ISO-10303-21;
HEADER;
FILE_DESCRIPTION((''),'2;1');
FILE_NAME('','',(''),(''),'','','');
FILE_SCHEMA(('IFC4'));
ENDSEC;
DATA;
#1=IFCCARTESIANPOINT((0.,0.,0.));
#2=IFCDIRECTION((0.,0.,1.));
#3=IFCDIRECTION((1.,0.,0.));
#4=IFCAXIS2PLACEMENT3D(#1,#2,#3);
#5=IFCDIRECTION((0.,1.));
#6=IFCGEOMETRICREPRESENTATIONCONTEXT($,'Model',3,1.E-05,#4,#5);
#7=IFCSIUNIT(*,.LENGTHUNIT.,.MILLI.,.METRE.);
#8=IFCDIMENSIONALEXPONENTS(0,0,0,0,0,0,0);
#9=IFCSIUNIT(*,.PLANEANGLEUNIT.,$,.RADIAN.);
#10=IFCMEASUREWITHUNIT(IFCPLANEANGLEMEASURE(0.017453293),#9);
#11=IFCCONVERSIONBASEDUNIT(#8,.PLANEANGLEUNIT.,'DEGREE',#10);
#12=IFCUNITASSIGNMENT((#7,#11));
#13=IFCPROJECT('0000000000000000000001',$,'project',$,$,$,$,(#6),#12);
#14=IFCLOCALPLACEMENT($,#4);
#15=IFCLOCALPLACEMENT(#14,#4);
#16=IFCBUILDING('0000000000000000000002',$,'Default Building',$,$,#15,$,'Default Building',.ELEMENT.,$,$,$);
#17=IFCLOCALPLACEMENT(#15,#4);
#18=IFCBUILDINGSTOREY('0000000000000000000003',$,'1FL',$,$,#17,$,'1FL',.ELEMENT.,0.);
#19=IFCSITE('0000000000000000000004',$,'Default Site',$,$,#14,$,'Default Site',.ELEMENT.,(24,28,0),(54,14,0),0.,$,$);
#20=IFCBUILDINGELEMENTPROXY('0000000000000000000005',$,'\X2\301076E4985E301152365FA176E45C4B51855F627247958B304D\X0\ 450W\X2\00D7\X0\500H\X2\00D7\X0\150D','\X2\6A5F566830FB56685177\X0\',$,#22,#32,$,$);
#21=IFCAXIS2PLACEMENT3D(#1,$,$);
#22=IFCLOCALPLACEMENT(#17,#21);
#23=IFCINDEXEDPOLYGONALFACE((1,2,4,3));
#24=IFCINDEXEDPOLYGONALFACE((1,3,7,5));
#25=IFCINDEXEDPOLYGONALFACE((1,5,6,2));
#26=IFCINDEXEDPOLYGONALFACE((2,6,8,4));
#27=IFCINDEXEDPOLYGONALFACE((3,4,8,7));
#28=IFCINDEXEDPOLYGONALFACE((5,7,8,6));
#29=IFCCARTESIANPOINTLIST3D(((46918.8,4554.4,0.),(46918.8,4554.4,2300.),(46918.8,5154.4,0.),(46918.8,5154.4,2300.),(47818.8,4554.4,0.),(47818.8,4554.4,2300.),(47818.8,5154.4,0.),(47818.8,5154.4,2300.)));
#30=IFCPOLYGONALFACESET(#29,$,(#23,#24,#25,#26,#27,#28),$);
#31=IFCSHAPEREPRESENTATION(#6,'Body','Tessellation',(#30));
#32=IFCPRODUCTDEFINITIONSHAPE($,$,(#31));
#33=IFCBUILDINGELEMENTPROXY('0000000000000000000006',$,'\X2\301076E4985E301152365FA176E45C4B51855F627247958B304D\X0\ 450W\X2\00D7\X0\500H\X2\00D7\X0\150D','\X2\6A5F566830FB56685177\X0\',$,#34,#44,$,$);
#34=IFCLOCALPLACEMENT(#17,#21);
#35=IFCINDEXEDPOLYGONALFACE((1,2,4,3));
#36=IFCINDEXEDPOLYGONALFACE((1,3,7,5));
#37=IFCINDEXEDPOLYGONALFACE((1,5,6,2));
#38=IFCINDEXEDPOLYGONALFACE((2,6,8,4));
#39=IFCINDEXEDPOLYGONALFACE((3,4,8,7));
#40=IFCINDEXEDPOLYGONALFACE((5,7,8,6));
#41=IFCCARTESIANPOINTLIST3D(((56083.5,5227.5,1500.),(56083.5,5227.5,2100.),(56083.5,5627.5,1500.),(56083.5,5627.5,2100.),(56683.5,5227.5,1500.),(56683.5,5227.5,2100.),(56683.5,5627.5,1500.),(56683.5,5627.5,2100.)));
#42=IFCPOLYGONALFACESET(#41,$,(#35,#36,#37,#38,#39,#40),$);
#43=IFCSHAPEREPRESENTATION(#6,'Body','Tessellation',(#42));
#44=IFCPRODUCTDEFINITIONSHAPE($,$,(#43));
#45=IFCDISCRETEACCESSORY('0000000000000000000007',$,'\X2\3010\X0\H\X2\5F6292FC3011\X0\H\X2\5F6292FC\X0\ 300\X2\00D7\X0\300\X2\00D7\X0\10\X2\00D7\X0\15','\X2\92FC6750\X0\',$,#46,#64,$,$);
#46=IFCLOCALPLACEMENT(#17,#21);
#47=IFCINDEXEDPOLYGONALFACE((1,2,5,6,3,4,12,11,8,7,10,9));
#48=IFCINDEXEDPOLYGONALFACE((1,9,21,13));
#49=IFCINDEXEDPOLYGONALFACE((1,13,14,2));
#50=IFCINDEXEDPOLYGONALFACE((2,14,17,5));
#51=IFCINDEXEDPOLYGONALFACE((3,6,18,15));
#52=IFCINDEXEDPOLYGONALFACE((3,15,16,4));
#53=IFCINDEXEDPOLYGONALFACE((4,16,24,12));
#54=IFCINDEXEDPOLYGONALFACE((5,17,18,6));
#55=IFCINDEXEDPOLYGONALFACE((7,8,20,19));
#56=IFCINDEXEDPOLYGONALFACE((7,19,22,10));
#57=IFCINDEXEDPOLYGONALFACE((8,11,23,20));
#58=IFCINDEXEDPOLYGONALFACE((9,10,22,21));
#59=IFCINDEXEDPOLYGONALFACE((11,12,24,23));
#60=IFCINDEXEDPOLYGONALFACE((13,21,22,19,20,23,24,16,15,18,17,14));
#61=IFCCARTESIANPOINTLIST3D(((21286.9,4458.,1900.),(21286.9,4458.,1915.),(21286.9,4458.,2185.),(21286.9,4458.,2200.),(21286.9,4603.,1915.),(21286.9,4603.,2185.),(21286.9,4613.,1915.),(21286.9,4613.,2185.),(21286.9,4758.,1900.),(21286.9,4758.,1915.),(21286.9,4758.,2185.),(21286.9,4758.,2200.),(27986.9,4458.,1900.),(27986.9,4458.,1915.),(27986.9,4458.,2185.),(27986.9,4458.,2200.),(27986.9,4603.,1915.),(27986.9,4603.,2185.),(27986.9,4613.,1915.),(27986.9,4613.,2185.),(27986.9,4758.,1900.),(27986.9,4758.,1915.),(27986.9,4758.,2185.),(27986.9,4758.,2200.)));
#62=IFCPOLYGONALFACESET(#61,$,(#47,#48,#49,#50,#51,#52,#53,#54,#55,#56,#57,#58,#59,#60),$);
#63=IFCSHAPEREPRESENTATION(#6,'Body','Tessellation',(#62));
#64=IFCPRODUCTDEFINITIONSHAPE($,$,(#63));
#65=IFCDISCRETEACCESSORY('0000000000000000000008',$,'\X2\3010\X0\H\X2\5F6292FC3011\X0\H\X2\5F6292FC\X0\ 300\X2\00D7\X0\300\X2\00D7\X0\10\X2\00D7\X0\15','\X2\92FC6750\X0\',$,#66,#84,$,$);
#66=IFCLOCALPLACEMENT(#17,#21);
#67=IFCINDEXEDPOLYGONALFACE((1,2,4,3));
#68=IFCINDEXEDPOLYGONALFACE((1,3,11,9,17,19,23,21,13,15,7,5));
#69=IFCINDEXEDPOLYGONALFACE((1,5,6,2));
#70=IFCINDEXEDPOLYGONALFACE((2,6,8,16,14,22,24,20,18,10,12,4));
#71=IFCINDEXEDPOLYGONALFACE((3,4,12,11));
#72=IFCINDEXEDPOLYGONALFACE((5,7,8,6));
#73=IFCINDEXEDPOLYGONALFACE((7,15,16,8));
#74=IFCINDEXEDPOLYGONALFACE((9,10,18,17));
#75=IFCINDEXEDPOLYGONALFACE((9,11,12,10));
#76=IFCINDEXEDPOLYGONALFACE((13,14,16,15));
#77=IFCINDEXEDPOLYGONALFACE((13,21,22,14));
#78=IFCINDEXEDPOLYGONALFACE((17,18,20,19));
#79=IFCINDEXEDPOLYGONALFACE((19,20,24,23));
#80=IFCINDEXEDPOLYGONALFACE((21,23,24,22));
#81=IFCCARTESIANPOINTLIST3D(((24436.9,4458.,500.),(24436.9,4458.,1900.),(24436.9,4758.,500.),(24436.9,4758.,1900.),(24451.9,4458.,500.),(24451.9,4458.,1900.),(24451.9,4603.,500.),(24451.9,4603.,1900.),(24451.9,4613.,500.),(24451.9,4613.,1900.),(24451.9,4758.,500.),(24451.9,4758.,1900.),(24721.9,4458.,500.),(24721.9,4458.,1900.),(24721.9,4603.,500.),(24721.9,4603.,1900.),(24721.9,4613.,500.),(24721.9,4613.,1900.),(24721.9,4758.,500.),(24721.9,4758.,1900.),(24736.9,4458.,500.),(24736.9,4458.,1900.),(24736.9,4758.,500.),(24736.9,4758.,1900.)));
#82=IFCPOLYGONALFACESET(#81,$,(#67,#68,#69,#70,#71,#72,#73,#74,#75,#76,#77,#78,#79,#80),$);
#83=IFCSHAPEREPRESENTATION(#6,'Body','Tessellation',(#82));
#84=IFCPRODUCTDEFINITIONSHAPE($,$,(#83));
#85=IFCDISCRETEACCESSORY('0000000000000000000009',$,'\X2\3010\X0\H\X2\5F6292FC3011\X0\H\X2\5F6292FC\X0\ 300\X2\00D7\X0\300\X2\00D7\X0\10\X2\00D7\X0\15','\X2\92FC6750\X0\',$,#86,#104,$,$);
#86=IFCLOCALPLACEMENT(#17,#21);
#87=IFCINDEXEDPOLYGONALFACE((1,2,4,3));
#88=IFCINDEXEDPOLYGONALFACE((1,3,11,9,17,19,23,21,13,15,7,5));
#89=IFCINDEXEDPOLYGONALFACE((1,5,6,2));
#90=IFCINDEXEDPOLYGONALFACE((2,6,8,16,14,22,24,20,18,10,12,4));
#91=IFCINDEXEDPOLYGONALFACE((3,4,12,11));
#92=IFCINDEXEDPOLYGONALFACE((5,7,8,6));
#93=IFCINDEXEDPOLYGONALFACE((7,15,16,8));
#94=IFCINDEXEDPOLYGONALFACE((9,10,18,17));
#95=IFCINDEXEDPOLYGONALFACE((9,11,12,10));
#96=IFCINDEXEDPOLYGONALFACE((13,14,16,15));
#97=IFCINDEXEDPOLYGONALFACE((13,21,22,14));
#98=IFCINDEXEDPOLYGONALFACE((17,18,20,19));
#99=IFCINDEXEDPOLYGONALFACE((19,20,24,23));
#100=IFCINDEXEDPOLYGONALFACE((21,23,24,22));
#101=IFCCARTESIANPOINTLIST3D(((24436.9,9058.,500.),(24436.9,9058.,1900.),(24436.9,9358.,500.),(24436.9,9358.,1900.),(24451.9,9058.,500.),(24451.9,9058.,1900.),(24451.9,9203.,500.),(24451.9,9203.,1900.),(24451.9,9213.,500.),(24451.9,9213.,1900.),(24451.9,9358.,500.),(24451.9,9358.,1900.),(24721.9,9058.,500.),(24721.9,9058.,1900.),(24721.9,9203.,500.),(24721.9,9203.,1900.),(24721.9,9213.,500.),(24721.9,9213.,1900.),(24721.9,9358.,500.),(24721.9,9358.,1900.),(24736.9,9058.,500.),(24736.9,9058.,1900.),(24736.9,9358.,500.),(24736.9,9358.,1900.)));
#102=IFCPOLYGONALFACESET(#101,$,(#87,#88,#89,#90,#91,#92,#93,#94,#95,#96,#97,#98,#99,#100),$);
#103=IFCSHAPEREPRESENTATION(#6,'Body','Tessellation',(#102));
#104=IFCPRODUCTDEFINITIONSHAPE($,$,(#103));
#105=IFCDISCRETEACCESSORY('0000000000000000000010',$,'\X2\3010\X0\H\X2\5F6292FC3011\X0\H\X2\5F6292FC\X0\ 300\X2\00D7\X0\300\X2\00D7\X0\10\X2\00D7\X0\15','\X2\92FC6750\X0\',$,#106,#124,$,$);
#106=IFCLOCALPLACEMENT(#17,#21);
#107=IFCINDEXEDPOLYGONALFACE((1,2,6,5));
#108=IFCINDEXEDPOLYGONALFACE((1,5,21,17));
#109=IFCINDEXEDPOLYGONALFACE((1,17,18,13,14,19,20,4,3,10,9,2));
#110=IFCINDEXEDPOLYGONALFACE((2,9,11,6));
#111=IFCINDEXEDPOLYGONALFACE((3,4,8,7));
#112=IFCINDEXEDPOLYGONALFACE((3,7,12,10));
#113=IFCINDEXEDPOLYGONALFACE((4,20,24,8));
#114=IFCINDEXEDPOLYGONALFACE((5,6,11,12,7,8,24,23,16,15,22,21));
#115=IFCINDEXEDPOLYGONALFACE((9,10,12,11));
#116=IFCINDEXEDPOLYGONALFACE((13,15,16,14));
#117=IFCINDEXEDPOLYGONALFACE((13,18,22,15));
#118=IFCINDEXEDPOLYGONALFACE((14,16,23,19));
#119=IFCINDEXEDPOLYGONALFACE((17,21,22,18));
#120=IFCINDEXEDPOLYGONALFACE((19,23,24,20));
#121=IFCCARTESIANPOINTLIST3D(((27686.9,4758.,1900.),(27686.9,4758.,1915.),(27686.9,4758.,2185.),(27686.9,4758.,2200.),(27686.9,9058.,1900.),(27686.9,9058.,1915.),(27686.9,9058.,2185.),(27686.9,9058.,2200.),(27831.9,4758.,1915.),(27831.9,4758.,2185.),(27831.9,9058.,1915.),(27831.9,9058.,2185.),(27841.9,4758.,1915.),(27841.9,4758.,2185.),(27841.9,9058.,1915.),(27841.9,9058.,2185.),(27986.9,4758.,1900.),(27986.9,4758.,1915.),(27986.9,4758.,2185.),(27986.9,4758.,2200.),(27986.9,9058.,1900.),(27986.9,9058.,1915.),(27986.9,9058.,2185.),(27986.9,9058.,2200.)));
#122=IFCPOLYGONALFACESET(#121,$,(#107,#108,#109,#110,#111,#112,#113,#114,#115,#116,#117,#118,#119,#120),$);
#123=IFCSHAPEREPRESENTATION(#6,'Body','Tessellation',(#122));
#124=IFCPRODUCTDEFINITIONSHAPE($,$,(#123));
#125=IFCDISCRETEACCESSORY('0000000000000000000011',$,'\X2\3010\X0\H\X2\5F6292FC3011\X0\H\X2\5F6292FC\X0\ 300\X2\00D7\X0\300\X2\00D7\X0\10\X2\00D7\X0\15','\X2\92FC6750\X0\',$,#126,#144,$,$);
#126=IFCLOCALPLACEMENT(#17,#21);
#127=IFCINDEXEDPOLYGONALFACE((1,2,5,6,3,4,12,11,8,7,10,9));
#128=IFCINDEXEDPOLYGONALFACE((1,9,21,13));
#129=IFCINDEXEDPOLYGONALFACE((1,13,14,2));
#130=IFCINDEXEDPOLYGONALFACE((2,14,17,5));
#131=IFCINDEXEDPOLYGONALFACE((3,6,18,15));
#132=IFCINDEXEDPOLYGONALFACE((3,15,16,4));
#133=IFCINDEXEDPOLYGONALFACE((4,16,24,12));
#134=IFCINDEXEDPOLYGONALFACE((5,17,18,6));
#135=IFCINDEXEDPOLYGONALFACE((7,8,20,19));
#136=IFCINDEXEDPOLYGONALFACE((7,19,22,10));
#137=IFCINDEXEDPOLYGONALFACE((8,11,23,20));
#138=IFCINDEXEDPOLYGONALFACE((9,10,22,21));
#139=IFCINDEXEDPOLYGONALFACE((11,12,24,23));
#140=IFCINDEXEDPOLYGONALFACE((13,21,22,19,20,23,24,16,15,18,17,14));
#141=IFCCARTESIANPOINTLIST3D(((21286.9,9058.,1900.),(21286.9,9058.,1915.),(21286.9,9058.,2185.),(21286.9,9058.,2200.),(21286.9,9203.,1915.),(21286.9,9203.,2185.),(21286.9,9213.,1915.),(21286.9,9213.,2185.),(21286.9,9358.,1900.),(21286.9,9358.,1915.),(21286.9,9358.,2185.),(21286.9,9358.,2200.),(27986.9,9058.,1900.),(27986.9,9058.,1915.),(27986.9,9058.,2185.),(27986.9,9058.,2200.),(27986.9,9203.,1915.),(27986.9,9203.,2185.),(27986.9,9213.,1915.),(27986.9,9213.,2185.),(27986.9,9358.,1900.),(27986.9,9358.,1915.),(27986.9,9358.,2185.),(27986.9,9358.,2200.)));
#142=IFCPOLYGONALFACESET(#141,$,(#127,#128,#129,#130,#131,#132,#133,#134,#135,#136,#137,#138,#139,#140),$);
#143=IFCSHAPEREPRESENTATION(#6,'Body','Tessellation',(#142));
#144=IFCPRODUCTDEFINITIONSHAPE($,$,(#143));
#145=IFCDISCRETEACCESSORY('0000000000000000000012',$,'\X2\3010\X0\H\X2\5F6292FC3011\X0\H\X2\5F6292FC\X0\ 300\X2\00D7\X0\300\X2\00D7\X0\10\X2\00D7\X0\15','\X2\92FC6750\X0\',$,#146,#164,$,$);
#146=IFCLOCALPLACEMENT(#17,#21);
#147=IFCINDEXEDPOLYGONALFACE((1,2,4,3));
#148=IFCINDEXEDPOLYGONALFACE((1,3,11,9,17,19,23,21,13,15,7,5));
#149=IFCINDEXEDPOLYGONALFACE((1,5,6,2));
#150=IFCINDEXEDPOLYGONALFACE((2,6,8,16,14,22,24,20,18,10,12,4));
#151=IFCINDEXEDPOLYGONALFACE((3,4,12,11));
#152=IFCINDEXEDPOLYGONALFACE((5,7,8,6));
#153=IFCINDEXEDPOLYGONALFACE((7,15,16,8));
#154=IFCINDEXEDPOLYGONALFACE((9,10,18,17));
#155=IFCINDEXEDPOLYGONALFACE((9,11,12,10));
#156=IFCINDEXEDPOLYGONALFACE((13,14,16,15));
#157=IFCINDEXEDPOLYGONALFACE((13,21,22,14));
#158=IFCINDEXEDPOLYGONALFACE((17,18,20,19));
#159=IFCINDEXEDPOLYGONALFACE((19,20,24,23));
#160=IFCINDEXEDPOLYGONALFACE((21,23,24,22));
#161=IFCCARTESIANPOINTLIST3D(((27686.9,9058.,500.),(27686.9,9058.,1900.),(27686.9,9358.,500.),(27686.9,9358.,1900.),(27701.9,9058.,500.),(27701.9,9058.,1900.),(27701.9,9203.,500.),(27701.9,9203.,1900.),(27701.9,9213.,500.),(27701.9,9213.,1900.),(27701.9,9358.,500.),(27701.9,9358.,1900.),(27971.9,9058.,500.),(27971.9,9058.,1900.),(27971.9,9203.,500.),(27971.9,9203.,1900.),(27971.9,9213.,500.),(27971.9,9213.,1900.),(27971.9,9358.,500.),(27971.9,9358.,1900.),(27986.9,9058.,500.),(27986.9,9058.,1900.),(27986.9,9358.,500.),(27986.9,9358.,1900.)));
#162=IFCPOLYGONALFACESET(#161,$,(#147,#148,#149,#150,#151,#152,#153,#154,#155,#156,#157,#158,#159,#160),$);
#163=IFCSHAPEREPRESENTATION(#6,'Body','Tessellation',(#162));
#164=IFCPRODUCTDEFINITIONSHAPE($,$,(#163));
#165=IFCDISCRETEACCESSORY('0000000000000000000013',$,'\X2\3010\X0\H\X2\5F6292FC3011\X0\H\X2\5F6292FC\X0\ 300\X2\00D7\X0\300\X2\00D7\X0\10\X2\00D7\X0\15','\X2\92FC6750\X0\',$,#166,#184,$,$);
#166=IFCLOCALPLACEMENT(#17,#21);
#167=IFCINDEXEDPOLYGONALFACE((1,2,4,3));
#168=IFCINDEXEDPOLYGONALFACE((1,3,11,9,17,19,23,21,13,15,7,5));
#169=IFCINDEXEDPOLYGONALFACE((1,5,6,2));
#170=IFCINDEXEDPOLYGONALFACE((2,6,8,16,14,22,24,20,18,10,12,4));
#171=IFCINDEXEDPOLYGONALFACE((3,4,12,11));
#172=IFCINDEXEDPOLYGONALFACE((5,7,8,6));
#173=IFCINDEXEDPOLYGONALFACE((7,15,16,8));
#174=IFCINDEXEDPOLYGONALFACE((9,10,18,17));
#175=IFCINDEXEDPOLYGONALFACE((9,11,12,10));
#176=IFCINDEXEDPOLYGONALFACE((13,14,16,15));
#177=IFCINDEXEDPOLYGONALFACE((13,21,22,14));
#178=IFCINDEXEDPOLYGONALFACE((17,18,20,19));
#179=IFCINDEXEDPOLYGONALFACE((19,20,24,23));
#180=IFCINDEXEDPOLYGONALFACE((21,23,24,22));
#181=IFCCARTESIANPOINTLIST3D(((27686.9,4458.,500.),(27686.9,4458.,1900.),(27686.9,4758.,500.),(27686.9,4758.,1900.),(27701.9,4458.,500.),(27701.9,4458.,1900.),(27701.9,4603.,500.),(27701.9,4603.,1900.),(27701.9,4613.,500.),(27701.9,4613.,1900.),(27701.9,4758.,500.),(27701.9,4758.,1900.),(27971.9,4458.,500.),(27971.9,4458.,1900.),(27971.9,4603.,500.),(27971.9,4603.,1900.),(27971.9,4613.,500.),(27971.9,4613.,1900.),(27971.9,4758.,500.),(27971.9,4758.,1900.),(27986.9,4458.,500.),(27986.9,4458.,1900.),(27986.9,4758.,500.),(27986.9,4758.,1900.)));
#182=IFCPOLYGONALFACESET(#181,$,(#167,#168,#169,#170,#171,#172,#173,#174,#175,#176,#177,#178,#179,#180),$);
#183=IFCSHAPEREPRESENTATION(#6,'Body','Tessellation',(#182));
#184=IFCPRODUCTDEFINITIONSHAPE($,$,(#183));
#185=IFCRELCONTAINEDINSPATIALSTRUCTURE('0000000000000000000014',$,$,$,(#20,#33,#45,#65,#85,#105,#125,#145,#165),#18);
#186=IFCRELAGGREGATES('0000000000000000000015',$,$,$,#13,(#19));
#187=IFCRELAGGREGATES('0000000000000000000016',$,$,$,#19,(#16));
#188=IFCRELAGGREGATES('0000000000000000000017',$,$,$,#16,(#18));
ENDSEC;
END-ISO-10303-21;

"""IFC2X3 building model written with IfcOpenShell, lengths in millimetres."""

from ifc_helpers import new_model, entity, si_unit, converted_unit, direction, frame, origin_with_axes, origin_2d_with_axis, place, context, project, spatial, rectangle, i_section, extrude, source, transform, mapped, element, save


model = new_model("IFC2X3")

# Units and contexts
model_context = context("Model", 3, precision=1e-05, world=origin_with_axes(), true_north=direction((0.0, 1.0)))
ifc_project = project(units=[si_unit("LENGTHUNIT", "METRE", prefix="MILLI"), converted_unit("PLANEANGLEUNIT", "DEGREE", entity("IfcPlaneAngleMeasure", 0.017453293), si_unit("PLANEANGLEUNIT", "RADIAN"), dimensions=[0, 0, 0, 0, 0, 0, 0])], contexts=[model_context])

# Site, building, storey
site_placement = place(None, origin_with_axes())
site = spatial("IfcSite", under=ifc_project, at=site_placement, Name="Default Site", LongName="Default Site", CompositionType="ELEMENT", RefLatitude=(24, 28, 0), RefLongitude=(54, 14, 0), RefElevation=0.0)
building_placement = place(site_placement, origin_with_axes())
building = spatial("IfcBuilding", under=site, at=building_placement, Name="Default Building", LongName="Default Building", CompositionType="ELEMENT")
storey_placement = place(building_placement, origin_with_axes())
storey = spatial("IfcBuildingStorey", under=building, at=storey_placement, Name="1FL", LongName="1FL", CompositionType="ELEMENT", Elevation=0.0)

# Electric distribution points
shared_shape_1 = source(origin_with_axes(), model_context, "Body", "SweptSolid", [
    extrude(rectangle(XDim=900.0, YDim=600.0, at=origin_2d_with_axis()), frame((0.0, -300.0, 0.0), z_axis=(0.0, 0.0, 1.0), x_axis=(1.0, 0.0, 0.0)), (0.0, 0.0, 1.0), 2300.0),
])
electric_distribution_point_1_placement = place(storey_placement, frame((47368.8, 5154.4, 0.0), z_axis=(0.0, 0.0, 1.0), x_axis=(1.0, 0.0, 0.0)))
element("IfcElectricDistributionPoint", 1, at=electric_distribution_point_1_placement, inside=storey, Name="【盤類】制御盤屋内形片開き 450W×500H×150D", Description="機器・器具", DistributionPointFunction="NOTDEFINED", context=model_context, shape_type="MappedRepresentation", body=[
    mapped(shared_shape_1, transform((0.0, 0.0, 0.0))),
])
shared_shape_2 = source(origin_with_axes(), model_context, "Body", "SweptSolid", [
    extrude(rectangle(XDim=600.0, YDim=400.0, at=origin_2d_with_axis()), frame((0.0, -200.0, 0.0), z_axis=(0.0, 0.0, 1.0), x_axis=(1.0, 0.0, 0.0)), (0.0, 0.0, 1.0), 600.0),
])
electric_distribution_point_2_placement = place(storey_placement, frame((56383.5, 5627.5, 1500.0), z_axis=(0.0, 0.0, 1.0), x_axis=(1.0, 0.0, 0.0)))
element("IfcElectricDistributionPoint", 2, at=electric_distribution_point_2_placement, inside=storey, Name="【盤類】制御盤屋内形片開き 450W×500H×150D", Description="機器・器具", DistributionPointFunction="NOTDEFINED", context=model_context, shape_type="MappedRepresentation", body=[
    mapped(shared_shape_2, transform((0.0, 0.0, 0.0))),
])

# Discrete accessories
shared_shape_3 = source(origin_with_axes(), model_context, "Body", "SweptSolid", [
    extrude(i_section(OverallWidth=300.0, OverallDepth=300.0, WebThickness=10.0, FlangeThickness=15.0, at=origin_2d_with_axis()), frame((3350.0, 0.0, -150.0), z_axis=(-1.0, 0.0, 0.0), x_axis=(0.0, -1.0, 0.0)), (0.0, 0.0, 1.0), 6700.0),
])
discrete_accessory_1_placement = place(storey_placement, frame((24636.9, 4608.0, 2200.0), z_axis=(0.0, 0.0, 1.0), x_axis=(1.0, 0.0, 0.0)))
element("IfcDiscreteAccessory", 3, at=discrete_accessory_1_placement, inside=storey, Name="【H形鋼】H形鋼 300×300×10×15", Description="鋼材", context=model_context, shape_type="MappedRepresentation", body=[
    mapped(shared_shape_3, transform((0.0, 0.0, 0.0))),
])
shared_shape_4 = source(origin_with_axes(), model_context, "Body", "SweptSolid", [
    extrude(i_section(OverallWidth=300.0, OverallDepth=300.0, WebThickness=10.0, FlangeThickness=15.0, at=origin_2d_with_axis()), frame((700.0, 0.0, -150.0), z_axis=(-1.0, 0.0, 0.0), x_axis=(0.0, -1.0, 0.0)), (0.0, 0.0, 1.0), 1400.0),
])
discrete_accessory_2_placement = place(storey_placement, frame((24436.9, 4608.0, 1200.0), z_axis=(-1.0, 0.0, 0.0), x_axis=(0.0, 0.0, 1.0)))
element("IfcDiscreteAccessory", 4, at=discrete_accessory_2_placement, inside=storey, Name="【H形鋼】H形鋼 300×300×10×15", Description="鋼材", context=model_context, shape_type="MappedRepresentation", body=[
    mapped(shared_shape_4, transform((0.0, 0.0, 0.0))),
])
shared_shape_5 = source(origin_with_axes(), model_context, "Body", "SweptSolid", [
    extrude(i_section(OverallWidth=300.0, OverallDepth=300.0, WebThickness=10.0, FlangeThickness=15.0, at=origin_2d_with_axis()), frame((700.0, 0.0, -150.0), z_axis=(-1.0, 0.0, 0.0), x_axis=(0.0, -1.0, 0.0)), (0.0, 0.0, 1.0), 1400.0),
])
discrete_accessory_3_placement = place(storey_placement, frame((24436.9, 9208.0, 1200.0), z_axis=(-1.0, 0.0, 0.0), x_axis=(0.0, 0.0, 1.0)))
element("IfcDiscreteAccessory", 5, at=discrete_accessory_3_placement, inside=storey, Name="【H形鋼】H形鋼 300×300×10×15", Description="鋼材", context=model_context, shape_type="MappedRepresentation", body=[
    mapped(shared_shape_5, transform((0.0, 0.0, 0.0))),
])
shared_shape_6 = source(origin_with_axes(), model_context, "Body", "SweptSolid", [
    extrude(i_section(OverallWidth=300.0, OverallDepth=300.0, WebThickness=10.0, FlangeThickness=15.0, at=origin_2d_with_axis()), frame((2150.0, 0.0, -150.0), z_axis=(-1.0, 0.0, 0.0), x_axis=(0.0, -1.0, 0.0)), (0.0, 0.0, 1.0), 4300.0),
])
discrete_accessory_4_placement = place(storey_placement, frame((27836.9, 6908.0, 2200.0), z_axis=(0.0, 0.0, 1.0), x_axis=(0.0, 1.0, 0.0)))
element("IfcDiscreteAccessory", 6, at=discrete_accessory_4_placement, inside=storey, Name="【H形鋼】H形鋼 300×300×10×15", Description="鋼材", context=model_context, shape_type="MappedRepresentation", body=[
    mapped(shared_shape_6, transform((0.0, 0.0, 0.0))),
])
shared_shape_7 = source(origin_with_axes(), model_context, "Body", "SweptSolid", [
    extrude(i_section(OverallWidth=300.0, OverallDepth=300.0, WebThickness=10.0, FlangeThickness=15.0, at=origin_2d_with_axis()), frame((3350.0, 0.0, -150.0), z_axis=(-1.0, 0.0, 0.0), x_axis=(0.0, -1.0, 0.0)), (0.0, 0.0, 1.0), 6700.0),
])
discrete_accessory_5_placement = place(storey_placement, frame((24636.9, 9208.0, 2200.0), z_axis=(0.0, 0.0, 1.0), x_axis=(-1.0, 0.0, 0.0)))
element("IfcDiscreteAccessory", 7, at=discrete_accessory_5_placement, inside=storey, Name="【H形鋼】H形鋼 300×300×10×15", Description="鋼材", context=model_context, shape_type="MappedRepresentation", body=[
    mapped(shared_shape_7, transform((0.0, 0.0, 0.0))),
])
shared_shape_8 = source(origin_with_axes(), model_context, "Body", "SweptSolid", [
    extrude(i_section(OverallWidth=300.0, OverallDepth=300.0, WebThickness=10.0, FlangeThickness=15.0, at=origin_2d_with_axis()), frame((700.0, 0.0, -150.0), z_axis=(-1.0, 0.0, 0.0), x_axis=(0.0, -1.0, 0.0)), (0.0, 0.0, 1.0), 1400.0),
])
discrete_accessory_6_placement = place(storey_placement, frame((27686.9, 9208.0, 1200.0), z_axis=(-1.0, 0.0, 0.0), x_axis=(0.0, 0.0, 1.0)))
element("IfcDiscreteAccessory", 8, at=discrete_accessory_6_placement, inside=storey, Name="【H形鋼】H形鋼 300×300×10×15", Description="鋼材", context=model_context, shape_type="MappedRepresentation", body=[
    mapped(shared_shape_8, transform((0.0, 0.0, 0.0))),
])
shared_shape_9 = source(origin_with_axes(), model_context, "Body", "SweptSolid", [
    extrude(i_section(OverallWidth=300.0, OverallDepth=300.0, WebThickness=10.0, FlangeThickness=15.0, at=origin_2d_with_axis()), frame((700.0, 0.0, -150.0), z_axis=(-1.0, 0.0, 0.0), x_axis=(0.0, -1.0, 0.0)), (0.0, 0.0, 1.0), 1400.0),
])
discrete_accessory_7_placement = place(storey_placement, frame((27686.9, 4608.0, 1200.0), z_axis=(-1.0, 0.0, 0.0), x_axis=(0.0, 0.0, 1.0)))
element("IfcDiscreteAccessory", 9, at=discrete_accessory_7_placement, inside=storey, Name="【H形鋼】H形鋼 300×300×10×15", Description="鋼材", context=model_context, shape_type="MappedRepresentation", body=[
    mapped(shared_shape_9, transform((0.0, 0.0, 0.0))),
])

save(model, "model.ifc")
